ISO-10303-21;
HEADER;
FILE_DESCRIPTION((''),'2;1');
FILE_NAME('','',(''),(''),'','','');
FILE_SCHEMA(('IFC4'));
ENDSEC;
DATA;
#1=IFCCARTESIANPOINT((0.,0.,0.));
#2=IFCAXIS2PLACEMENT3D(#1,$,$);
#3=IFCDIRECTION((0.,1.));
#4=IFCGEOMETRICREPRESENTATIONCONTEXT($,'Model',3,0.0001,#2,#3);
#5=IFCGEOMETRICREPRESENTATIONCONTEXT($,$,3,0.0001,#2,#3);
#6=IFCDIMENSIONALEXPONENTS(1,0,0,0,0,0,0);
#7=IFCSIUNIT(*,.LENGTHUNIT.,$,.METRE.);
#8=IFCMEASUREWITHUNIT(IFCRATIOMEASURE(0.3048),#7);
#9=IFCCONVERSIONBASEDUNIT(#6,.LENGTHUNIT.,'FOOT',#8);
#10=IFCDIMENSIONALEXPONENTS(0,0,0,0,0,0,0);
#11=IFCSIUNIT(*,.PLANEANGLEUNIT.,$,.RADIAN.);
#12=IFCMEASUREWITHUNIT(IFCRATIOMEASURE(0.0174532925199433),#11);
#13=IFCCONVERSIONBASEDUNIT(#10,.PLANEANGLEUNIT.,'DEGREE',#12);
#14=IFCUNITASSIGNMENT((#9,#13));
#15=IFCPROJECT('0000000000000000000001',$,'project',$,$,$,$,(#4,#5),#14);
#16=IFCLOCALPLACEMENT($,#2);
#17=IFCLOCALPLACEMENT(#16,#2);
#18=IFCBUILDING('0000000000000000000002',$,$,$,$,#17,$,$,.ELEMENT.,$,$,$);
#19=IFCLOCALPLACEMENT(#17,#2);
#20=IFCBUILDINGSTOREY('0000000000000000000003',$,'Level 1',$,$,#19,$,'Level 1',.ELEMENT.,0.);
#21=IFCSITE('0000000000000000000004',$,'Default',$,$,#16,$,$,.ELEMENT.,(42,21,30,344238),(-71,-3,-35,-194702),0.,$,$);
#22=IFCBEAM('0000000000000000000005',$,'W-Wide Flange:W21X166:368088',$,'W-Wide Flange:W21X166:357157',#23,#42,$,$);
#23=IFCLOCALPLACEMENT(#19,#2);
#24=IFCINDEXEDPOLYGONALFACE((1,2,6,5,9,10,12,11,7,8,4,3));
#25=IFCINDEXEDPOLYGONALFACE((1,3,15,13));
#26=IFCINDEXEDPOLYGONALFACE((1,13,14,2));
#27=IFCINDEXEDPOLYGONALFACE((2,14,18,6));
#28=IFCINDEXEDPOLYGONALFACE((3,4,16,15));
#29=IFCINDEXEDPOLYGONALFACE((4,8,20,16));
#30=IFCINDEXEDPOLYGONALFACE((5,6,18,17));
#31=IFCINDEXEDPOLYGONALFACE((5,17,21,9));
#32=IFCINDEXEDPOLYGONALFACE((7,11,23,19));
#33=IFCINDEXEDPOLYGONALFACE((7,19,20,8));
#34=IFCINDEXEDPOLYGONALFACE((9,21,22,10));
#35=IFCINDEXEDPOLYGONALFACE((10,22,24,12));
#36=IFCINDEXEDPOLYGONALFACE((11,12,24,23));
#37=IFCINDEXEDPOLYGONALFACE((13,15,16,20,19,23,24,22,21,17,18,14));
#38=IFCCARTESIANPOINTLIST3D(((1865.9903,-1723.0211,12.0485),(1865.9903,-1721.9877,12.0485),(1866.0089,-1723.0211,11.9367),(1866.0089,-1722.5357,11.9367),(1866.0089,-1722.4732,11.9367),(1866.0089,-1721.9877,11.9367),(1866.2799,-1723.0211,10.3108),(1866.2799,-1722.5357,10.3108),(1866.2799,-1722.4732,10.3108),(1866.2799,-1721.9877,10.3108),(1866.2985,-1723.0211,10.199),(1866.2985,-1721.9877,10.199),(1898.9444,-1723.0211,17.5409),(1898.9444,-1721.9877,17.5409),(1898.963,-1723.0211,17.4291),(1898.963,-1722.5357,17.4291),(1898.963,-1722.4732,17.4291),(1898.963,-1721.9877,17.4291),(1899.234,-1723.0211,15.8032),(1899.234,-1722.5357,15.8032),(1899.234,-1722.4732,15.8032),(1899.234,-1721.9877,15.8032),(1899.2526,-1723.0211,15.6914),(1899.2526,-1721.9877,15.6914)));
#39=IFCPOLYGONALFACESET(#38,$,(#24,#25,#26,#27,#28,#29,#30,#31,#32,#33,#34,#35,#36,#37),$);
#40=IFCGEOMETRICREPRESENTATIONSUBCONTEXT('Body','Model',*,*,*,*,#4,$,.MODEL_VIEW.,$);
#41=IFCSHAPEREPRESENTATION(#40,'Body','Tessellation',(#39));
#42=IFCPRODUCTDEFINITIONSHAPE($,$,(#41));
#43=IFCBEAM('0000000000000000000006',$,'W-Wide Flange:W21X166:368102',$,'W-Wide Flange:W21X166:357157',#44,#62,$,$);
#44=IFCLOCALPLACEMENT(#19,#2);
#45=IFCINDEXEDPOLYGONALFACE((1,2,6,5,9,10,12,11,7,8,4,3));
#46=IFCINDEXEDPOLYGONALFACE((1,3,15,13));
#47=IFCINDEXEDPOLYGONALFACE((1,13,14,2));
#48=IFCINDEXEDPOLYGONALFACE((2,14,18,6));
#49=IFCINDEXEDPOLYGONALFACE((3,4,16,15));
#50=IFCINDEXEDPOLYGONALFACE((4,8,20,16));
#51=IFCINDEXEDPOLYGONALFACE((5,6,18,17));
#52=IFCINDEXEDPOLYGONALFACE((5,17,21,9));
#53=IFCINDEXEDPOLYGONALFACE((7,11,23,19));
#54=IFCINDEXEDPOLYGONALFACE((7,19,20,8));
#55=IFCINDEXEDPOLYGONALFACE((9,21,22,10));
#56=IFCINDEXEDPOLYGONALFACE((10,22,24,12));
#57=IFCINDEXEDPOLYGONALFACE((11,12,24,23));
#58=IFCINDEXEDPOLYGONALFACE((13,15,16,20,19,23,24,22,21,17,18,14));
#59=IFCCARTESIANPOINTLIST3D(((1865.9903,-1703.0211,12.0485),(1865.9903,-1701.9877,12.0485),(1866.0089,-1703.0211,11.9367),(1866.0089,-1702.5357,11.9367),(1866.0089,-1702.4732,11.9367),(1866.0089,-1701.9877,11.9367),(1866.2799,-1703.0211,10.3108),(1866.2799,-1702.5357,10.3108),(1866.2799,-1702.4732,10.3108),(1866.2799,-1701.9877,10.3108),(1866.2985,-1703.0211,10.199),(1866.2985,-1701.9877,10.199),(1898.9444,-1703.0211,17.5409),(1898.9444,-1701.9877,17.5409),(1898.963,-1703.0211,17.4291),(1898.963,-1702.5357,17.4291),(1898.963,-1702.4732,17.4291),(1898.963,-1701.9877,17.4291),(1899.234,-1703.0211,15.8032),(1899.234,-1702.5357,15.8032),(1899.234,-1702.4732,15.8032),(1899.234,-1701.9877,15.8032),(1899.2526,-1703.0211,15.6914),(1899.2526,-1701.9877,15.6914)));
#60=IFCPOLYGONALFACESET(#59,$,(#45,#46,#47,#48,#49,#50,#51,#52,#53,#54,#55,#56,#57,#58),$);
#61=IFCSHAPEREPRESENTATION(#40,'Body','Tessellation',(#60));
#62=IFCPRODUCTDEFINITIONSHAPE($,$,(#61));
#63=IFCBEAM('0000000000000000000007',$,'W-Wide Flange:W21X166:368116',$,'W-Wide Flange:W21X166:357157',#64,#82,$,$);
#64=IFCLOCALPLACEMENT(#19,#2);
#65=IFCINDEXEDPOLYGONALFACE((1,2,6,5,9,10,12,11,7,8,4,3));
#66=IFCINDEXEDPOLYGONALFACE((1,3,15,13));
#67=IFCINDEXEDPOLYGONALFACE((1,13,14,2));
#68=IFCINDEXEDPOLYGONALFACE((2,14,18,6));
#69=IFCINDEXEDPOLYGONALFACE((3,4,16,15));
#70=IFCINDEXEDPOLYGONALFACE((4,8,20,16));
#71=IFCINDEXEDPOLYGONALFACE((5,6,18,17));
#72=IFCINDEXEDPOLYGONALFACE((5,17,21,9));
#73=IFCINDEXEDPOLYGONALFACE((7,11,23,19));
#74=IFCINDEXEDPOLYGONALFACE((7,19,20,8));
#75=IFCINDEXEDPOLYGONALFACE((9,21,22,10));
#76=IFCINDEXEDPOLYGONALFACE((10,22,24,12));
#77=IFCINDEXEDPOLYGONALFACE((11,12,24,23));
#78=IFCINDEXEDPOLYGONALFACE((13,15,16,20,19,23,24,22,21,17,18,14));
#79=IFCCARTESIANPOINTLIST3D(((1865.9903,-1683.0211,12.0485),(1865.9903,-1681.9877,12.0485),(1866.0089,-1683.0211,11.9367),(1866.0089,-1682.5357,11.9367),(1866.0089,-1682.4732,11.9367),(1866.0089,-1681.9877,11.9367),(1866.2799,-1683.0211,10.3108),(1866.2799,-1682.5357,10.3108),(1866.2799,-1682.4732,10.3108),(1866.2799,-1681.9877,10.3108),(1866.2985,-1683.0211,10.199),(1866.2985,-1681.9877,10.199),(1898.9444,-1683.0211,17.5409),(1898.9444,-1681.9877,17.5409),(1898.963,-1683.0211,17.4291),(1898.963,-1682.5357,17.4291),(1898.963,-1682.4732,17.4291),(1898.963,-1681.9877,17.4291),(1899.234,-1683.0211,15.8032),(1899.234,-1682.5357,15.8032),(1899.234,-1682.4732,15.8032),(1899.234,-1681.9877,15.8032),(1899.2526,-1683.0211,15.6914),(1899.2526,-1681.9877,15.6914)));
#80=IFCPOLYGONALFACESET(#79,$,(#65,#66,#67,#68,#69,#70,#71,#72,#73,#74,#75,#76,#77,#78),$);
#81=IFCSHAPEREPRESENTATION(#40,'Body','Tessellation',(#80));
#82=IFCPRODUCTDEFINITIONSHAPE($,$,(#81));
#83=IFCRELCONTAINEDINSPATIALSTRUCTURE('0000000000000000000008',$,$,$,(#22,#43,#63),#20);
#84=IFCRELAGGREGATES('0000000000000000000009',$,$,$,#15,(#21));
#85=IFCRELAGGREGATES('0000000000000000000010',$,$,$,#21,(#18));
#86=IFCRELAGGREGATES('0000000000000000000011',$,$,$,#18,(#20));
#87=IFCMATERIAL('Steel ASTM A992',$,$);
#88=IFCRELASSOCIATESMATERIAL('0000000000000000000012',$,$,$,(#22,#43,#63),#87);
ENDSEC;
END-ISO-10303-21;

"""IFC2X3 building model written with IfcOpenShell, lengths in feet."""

from ifc_helpers import new_model, entity, si_unit, converted_unit, direction, frame, frame_2d, origin, place, context, subcontext, project, spatial, i_section, extrude, material, element, save


model = new_model("IFC2X3")

# Units and contexts
model_context = context("Model", 3, precision=0.0001, world=origin(), true_north=direction((0.0, 1.0)))
context_of_model = context(None, 3, precision=0.0001, world=origin(), true_north=direction((0.0, 1.0)))
body_context = subcontext(model_context, "Body", "Model", "MODEL_VIEW")
ifc_project = project(units=[converted_unit("LENGTHUNIT", "FOOT", entity("IfcRatioMeasure", 0.3048), si_unit("LENGTHUNIT", "METRE"), dimensions=[1, 0, 0, 0, 0, 0, 0]), converted_unit("PLANEANGLEUNIT", "DEGREE", entity("IfcRatioMeasure", 0.0174532925199433), si_unit("PLANEANGLEUNIT", "RADIAN"), dimensions=[0, 0, 0, 0, 0, 0, 0])], contexts=[model_context, context_of_model])

# Site, building, storey
site_placement = place(None, origin())
site = spatial("IfcSite", under=ifc_project, at=site_placement, Name="Default", CompositionType="ELEMENT", RefLatitude=(42, 21, 30, 344238), RefLongitude=(-71, -3, -35, -194702), RefElevation=0.0)
building_placement = place(site_placement, origin())
building = spatial("IfcBuilding", under=site, at=building_placement, CompositionType="ELEMENT")
storey_placement = place(building_placement, origin())
storey = spatial("IfcBuildingStorey", under=building, at=storey_placement, Name="Level 1", LongName="Level 1", CompositionType="ELEMENT", Elevation=0.0)

# Shared definitions
ifc_material_1 = material(Name="Steel ASTM A992")

# Beams
beam_1_placement = place(storey_placement, frame((1865.8276, -1722.5044, 12.0214), z_axis=(-0.164399, 0.0, 0.986394), x_axis=(0.986394, 0.0, 0.164399)))
element("IfcBeam", 1, at=beam_1_placement, inside=storey, material=ifc_material_1, Name="W-Wide Flange:W21X166:368088", ObjectType="W-Wide Flange:W21X166:357157", context=body_context, shape_type="SweptSolid", body=[
    extrude(i_section(OverallWidth=1.0333, OverallDepth=1.875, WebThickness=0.0625, FlangeThickness=0.1133, at=frame_2d((0.0, 0.0), x_axis=(0.0, 1.0))), frame((0.165, 0.0, -0.9375), z_axis=(1.0, 0.0, 0.0), x_axis=(0.0, 0.0, -1.0)), (0.0, 0.0, 1.0), 33.4087),
])
beam_2_placement = place(storey_placement, frame((1865.8276, -1702.5044, 12.0214), z_axis=(-0.164399, 0.0, 0.986394), x_axis=(0.986394, 0.0, 0.164399)))
element("IfcBeam", 2, at=beam_2_placement, inside=storey, material=ifc_material_1, Name="W-Wide Flange:W21X166:368102", ObjectType="W-Wide Flange:W21X166:357157", context=body_context, shape_type="SweptSolid", body=[
    extrude(i_section(OverallWidth=1.0333, OverallDepth=1.875, WebThickness=0.0625, FlangeThickness=0.1133, at=frame_2d((0.0, 0.0), x_axis=(0.0, 1.0))), frame((0.165, 0.0, -0.9375), z_axis=(1.0, 0.0, 0.0), x_axis=(0.0, 0.0, -1.0)), (0.0, 0.0, 1.0), 33.4087),
])
beam_3_placement = place(storey_placement, frame((1865.8276, -1682.5044, 12.0214), z_axis=(-0.164399, 0.0, 0.986394), x_axis=(0.986394, 0.0, 0.164399)))
element("IfcBeam", 3, at=beam_3_placement, inside=storey, material=ifc_material_1, Name="W-Wide Flange:W21X166:368116", ObjectType="W-Wide Flange:W21X166:357157", context=body_context, shape_type="SweptSolid", body=[
    extrude(i_section(OverallWidth=1.0333, OverallDepth=1.875, WebThickness=0.0625, FlangeThickness=0.1133, at=frame_2d((0.0, 0.0), x_axis=(0.0, 1.0))), frame((0.165, 0.0, -0.9375), z_axis=(1.0, 0.0, 0.0), x_axis=(0.0, 0.0, -1.0)), (0.0, 0.0, 1.0), 33.4087),
])

save(model, "model.ifc")
